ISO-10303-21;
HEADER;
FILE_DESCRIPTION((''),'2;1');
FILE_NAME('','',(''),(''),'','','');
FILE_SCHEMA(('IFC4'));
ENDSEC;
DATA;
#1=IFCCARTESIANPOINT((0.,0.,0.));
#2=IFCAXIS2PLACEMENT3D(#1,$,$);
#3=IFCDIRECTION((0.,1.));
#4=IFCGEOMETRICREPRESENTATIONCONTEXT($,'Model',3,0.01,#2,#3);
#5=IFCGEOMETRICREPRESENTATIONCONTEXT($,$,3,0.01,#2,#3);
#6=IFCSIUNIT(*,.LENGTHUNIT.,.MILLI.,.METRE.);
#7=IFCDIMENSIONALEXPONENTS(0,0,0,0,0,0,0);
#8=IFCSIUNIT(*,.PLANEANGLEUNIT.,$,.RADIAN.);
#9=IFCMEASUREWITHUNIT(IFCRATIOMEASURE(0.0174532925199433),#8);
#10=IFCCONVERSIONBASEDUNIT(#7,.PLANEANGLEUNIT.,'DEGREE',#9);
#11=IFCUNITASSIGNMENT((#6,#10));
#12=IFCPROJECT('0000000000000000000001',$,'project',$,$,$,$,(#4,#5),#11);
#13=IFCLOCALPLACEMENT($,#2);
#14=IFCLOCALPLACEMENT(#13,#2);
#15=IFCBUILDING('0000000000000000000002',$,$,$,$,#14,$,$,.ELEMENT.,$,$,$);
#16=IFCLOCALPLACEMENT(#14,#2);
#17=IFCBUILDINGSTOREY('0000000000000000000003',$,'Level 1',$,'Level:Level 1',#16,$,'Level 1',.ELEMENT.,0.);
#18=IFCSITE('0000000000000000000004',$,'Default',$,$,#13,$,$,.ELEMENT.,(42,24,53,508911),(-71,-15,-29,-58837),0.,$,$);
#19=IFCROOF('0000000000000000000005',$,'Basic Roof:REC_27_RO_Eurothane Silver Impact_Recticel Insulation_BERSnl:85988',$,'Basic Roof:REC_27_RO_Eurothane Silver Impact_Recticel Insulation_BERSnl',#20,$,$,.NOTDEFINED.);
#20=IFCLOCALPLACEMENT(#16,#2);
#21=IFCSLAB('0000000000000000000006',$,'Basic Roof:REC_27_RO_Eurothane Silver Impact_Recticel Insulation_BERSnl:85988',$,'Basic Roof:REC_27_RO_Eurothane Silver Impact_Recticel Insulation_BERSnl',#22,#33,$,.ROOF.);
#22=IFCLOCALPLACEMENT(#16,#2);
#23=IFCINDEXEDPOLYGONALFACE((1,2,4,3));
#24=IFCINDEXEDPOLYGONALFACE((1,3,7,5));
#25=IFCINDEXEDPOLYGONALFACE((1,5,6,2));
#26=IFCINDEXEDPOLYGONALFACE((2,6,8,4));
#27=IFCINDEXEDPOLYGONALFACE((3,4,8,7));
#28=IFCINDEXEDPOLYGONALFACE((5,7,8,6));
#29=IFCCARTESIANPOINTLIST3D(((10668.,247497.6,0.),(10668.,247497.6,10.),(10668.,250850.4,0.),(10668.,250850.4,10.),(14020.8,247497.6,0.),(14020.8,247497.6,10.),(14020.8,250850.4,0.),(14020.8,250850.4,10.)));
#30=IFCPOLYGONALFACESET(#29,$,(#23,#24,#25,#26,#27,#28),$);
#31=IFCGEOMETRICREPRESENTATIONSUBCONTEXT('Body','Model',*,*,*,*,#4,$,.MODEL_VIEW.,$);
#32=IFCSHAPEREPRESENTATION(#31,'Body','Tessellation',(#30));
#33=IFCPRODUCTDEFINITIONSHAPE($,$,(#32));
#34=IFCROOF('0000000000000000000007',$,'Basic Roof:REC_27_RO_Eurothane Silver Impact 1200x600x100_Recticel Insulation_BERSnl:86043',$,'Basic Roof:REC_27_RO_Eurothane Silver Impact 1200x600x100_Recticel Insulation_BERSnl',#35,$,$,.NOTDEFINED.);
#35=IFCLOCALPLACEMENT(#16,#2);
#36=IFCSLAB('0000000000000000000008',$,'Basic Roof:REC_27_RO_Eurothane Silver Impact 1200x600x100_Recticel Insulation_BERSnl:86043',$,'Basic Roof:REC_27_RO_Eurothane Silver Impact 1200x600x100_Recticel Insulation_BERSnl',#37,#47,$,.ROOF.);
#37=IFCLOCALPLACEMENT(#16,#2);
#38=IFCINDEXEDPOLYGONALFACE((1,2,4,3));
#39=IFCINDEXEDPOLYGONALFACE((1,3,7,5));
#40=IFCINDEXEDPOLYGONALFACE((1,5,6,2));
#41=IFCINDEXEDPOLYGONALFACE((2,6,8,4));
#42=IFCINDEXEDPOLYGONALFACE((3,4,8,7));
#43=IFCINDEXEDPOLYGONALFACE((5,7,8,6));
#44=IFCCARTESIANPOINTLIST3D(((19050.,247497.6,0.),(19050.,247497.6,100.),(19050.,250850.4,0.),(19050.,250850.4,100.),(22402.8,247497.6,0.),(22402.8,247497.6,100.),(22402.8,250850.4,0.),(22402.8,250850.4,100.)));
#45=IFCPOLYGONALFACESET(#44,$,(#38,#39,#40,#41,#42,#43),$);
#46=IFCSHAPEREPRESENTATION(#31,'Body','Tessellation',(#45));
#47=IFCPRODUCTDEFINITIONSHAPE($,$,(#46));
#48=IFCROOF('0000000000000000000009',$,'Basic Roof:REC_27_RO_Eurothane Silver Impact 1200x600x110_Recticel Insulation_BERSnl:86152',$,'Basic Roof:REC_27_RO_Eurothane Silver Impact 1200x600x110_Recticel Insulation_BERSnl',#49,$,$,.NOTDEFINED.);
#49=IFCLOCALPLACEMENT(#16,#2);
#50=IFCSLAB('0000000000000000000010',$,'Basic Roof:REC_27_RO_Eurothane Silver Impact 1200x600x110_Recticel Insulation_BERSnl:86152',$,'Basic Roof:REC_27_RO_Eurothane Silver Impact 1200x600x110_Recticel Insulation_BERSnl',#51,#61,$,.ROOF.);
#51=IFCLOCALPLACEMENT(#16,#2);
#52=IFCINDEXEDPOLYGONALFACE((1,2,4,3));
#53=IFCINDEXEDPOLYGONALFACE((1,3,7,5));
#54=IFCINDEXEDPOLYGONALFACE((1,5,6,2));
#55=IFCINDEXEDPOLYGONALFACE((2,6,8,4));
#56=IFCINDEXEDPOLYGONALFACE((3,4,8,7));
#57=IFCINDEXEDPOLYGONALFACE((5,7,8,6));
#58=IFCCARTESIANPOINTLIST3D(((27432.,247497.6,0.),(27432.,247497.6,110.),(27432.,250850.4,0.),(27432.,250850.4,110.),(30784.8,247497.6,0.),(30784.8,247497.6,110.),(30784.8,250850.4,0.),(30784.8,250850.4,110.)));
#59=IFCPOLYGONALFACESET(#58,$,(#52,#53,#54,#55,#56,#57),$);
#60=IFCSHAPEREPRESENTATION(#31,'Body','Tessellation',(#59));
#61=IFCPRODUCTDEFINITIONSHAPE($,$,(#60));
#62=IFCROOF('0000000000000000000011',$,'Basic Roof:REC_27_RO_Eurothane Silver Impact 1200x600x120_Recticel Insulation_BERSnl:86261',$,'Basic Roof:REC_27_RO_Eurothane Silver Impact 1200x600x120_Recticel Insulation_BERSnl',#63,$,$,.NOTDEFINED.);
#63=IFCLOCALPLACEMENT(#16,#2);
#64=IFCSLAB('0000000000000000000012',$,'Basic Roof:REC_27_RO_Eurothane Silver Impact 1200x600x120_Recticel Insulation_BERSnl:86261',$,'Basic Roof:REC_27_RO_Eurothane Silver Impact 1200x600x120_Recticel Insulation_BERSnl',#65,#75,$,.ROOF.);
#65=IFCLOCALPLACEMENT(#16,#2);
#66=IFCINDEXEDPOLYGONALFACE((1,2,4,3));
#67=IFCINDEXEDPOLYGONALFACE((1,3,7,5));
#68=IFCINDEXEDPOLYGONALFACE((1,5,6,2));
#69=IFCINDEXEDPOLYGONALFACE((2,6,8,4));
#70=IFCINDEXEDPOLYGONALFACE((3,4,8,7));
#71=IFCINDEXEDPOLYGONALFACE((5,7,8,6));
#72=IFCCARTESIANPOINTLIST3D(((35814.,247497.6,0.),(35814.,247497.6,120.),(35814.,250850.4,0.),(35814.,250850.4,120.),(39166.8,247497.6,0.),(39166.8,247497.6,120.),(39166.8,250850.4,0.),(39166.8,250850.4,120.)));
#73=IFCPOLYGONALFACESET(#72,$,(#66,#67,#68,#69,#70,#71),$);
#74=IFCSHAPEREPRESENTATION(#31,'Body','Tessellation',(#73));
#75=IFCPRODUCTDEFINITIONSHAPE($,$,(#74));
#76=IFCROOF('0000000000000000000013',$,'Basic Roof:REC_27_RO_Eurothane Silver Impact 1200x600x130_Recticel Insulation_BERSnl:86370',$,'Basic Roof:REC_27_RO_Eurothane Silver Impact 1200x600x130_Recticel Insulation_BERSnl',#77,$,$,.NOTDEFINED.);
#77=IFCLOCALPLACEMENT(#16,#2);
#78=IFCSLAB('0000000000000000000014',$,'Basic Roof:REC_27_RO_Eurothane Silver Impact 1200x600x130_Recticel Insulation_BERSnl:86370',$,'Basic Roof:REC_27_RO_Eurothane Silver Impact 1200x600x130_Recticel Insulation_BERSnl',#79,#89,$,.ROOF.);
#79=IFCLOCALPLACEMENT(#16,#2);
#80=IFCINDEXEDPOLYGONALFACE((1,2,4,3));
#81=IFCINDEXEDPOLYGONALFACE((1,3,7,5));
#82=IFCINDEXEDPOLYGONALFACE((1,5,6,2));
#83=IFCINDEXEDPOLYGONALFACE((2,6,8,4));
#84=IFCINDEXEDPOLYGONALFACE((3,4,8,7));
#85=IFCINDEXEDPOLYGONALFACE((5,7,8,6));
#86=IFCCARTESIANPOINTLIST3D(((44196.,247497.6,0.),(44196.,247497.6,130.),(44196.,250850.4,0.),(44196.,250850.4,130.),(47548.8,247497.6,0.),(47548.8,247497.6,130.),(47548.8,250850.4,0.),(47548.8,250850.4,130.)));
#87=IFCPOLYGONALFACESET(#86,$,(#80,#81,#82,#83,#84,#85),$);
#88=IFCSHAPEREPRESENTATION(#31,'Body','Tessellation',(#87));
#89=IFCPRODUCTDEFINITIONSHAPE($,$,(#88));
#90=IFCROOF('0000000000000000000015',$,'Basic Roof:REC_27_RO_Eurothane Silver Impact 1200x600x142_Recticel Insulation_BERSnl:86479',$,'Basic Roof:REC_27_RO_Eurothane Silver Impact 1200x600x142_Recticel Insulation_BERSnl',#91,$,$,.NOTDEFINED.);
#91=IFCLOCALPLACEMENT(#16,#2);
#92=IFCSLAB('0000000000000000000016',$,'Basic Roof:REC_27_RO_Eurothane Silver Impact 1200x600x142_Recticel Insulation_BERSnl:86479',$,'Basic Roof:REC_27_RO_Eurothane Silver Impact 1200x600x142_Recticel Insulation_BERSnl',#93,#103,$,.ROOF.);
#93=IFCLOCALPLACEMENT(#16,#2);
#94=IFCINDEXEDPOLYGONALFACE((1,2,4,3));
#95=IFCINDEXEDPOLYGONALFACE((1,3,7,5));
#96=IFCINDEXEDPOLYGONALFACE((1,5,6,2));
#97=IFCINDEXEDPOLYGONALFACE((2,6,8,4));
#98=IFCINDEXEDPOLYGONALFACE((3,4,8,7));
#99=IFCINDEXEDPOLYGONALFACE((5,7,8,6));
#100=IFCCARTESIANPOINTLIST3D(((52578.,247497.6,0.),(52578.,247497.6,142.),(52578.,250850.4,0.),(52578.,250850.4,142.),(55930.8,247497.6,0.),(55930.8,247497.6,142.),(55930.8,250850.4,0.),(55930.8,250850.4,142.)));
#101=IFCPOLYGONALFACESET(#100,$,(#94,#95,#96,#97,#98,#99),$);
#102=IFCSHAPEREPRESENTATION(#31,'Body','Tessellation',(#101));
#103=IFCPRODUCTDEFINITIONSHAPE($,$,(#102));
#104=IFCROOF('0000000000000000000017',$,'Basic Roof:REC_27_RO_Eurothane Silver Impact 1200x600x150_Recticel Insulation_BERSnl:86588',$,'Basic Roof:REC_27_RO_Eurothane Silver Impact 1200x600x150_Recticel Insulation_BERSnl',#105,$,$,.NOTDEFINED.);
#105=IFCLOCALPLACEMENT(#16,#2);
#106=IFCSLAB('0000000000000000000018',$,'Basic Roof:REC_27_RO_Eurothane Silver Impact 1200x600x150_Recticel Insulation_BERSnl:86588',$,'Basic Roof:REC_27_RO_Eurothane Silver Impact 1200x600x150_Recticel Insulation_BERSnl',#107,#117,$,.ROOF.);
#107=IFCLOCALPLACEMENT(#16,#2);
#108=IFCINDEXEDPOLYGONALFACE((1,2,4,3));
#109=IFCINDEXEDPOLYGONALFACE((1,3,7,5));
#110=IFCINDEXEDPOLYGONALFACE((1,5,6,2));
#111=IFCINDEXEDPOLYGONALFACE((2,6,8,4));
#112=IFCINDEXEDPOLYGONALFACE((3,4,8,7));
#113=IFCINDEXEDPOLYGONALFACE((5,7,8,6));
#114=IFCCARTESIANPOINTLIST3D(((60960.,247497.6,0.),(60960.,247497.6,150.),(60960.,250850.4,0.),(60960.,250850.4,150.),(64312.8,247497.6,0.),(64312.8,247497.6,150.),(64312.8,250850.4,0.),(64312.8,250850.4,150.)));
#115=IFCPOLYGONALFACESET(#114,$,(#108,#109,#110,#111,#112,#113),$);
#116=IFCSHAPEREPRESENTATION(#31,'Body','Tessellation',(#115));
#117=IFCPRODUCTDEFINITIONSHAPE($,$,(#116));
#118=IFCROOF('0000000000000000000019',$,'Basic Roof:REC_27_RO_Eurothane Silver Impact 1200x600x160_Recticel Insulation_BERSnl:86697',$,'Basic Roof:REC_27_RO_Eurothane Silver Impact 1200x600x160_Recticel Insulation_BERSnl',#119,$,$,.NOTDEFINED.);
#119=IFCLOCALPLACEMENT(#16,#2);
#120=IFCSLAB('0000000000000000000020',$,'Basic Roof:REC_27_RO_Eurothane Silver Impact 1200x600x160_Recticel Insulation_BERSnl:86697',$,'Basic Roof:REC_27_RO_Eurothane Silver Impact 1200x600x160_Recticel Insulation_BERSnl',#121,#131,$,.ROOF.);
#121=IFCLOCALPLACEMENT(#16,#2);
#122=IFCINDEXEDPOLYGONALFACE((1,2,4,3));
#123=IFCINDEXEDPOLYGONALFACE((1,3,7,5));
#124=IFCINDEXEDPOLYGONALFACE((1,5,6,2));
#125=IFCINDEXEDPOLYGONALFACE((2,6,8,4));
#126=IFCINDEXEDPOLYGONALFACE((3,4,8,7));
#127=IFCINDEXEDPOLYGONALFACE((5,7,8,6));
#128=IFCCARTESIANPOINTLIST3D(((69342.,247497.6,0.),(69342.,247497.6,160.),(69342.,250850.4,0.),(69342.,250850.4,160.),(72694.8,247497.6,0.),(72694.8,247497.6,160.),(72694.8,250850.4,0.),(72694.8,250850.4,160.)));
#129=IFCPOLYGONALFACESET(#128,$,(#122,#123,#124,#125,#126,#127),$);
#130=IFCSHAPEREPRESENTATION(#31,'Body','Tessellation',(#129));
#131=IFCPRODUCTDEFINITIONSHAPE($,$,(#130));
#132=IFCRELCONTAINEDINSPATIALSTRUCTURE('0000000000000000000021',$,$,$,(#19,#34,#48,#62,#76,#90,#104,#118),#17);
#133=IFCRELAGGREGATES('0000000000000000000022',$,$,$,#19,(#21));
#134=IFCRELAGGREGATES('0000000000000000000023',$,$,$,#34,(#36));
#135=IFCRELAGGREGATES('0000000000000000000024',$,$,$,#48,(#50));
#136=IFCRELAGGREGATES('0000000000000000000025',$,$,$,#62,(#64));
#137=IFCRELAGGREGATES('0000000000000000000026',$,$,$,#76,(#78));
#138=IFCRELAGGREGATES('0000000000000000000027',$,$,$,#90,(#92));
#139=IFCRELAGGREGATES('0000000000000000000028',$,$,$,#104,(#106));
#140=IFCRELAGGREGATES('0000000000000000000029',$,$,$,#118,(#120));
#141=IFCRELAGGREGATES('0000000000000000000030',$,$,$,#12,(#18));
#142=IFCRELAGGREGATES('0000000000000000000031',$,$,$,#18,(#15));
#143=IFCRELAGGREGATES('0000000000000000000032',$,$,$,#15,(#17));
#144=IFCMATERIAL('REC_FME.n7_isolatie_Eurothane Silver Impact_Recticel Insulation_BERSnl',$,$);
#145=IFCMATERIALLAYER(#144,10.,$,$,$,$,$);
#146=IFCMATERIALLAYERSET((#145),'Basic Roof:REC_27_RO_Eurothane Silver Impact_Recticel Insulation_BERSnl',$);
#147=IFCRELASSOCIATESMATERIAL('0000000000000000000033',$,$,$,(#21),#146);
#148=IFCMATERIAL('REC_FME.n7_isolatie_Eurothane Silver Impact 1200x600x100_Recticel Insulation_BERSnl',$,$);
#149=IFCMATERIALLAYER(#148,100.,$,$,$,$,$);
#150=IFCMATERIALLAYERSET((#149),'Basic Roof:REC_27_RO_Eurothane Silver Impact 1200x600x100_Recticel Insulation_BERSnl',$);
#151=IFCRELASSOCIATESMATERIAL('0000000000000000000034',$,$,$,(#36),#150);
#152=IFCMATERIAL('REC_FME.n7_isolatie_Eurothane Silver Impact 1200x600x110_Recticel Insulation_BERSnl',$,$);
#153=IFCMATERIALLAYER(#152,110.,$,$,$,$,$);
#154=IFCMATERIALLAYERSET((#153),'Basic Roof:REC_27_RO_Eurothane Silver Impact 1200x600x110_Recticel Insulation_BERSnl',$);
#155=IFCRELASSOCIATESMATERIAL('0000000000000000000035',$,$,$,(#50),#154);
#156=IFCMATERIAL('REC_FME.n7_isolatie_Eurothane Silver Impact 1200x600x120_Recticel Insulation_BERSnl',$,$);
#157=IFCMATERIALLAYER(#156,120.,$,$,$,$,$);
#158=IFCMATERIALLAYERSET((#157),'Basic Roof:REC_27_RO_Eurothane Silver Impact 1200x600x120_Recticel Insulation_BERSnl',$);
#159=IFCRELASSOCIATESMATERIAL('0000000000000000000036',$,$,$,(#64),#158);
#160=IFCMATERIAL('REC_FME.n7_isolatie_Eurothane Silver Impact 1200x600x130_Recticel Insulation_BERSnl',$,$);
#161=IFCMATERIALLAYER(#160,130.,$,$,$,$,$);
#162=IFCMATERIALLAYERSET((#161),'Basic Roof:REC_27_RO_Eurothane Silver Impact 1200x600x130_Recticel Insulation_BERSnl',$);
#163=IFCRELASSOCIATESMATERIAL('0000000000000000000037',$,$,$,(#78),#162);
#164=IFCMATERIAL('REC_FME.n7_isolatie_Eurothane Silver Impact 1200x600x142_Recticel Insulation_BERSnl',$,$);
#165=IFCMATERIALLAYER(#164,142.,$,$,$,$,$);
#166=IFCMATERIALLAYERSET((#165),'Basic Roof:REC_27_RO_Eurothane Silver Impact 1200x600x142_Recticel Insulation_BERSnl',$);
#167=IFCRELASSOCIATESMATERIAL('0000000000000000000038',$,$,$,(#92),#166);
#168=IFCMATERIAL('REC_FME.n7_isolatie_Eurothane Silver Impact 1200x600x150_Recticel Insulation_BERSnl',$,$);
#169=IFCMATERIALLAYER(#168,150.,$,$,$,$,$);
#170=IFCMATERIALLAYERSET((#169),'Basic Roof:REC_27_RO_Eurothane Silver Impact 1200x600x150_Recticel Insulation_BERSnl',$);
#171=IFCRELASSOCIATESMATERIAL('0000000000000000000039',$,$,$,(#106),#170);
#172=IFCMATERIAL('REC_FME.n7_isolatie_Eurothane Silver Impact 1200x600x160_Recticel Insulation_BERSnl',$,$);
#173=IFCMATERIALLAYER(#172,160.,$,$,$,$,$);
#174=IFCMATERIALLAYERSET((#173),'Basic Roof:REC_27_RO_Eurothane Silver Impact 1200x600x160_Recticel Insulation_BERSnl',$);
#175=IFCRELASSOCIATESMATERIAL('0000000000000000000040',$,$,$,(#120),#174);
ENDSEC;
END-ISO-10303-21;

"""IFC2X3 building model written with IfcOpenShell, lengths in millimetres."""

from ifc_helpers import new_model, entity, si_unit, converted_unit, direction, frame, frame_2d, origin, place, context, subcontext, project, spatial, rectangle, extrude, material, layer, layer_set, element, aggregate, save


model = new_model("IFC2X3")

# Units and contexts
model_context = context("Model", 3, precision=0.01, world=origin(), true_north=direction((0.0, 1.0)))
context_of_model = context(None, 3, precision=0.01, world=origin(), true_north=direction((0.0, 1.0)))
body_context = subcontext(model_context, "Body", "Model", "MODEL_VIEW")
ifc_project = project(units=[si_unit("LENGTHUNIT", "METRE", prefix="MILLI"), converted_unit("PLANEANGLEUNIT", "DEGREE", entity("IfcRatioMeasure", 0.0174532925199433), si_unit("PLANEANGLEUNIT", "RADIAN"), dimensions=[0, 0, 0, 0, 0, 0, 0])], contexts=[model_context, context_of_model])

# Site, building, storey
site_placement = place(None, origin())
site = spatial("IfcSite", under=ifc_project, at=site_placement, Name="Default", CompositionType="ELEMENT", RefLatitude=(42, 24, 53, 508911), RefLongitude=(-71, -15, -29, -58837), RefElevation=0.0)
building_placement = place(site_placement, origin())
building = spatial("IfcBuilding", under=site, at=building_placement, CompositionType="ELEMENT")
storey_placement = place(building_placement, origin())
storey = spatial("IfcBuildingStorey", under=building, at=storey_placement, Name="Level 1", ObjectType="Level:Level 1", LongName="Level 1", CompositionType="ELEMENT", Elevation=0.0)

# Roofs, slabs
roof_1_placement = place(storey_placement, frame((10668.0, 247497.6, 0.0)))
roof_1 = element("IfcRoof", 1, at=roof_1_placement, inside=storey, Name="Basic Roof:REC_27_RO_Eurothane Silver Impact_Recticel Insulation_BERSnl:85988", ObjectType="Basic Roof:REC_27_RO_Eurothane Silver Impact_Recticel Insulation_BERSnl", ShapeType="NOTDEFINED")
ifc_material_1 = material(Name="REC_FME.n7_isolatie_Eurothane Silver Impact_Recticel Insulation_BERSnl")
ifc_layer_1 = layer(ifc_material_1, 10.0)
ifc_layer_set_1 = layer_set([ifc_layer_1], Name="Basic Roof:REC_27_RO_Eurothane Silver Impact_Recticel Insulation_BERSnl")
slab_1_placement = place(roof_1_placement, origin())
slab_1 = element("IfcSlab", 2, at=slab_1_placement, material=ifc_layer_set_1, Name="Basic Roof:REC_27_RO_Eurothane Silver Impact_Recticel Insulation_BERSnl:85988", ObjectType="Basic Roof:REC_27_RO_Eurothane Silver Impact_Recticel Insulation_BERSnl", PredefinedType="ROOF", context=body_context, shape_type="SweptSolid", body=[
    extrude(rectangle(XDim=3352.8, YDim=3352.8, at=frame_2d((0.0, 0.0), x_axis=(-1.0, 0.0))), frame((1676.4, 1676.4, 0.0)), (0.0, 0.0, 1.0), 10.0),
])
aggregate(roof_1, [slab_1])
roof_2_placement = place(storey_placement, frame((19050.0, 247497.6, 0.0)))
roof_2 = element("IfcRoof", 3, at=roof_2_placement, inside=storey, Name="Basic Roof:REC_27_RO_Eurothane Silver Impact 1200x600x100_Recticel Insulation_BERSnl:86043", ObjectType="Basic Roof:REC_27_RO_Eurothane Silver Impact 1200x600x100_Recticel Insulation_BERSnl", ShapeType="NOTDEFINED")
ifc_material_2 = material(Name="REC_FME.n7_isolatie_Eurothane Silver Impact 1200x600x100_Recticel Insulation_BERSnl")
ifc_layer_2 = layer(ifc_material_2, 100.0)
ifc_layer_set_2 = layer_set([ifc_layer_2], Name="Basic Roof:REC_27_RO_Eurothane Silver Impact 1200x600x100_Recticel Insulation_BERSnl")
slab_2_placement = place(roof_2_placement, origin())
slab_2 = element("IfcSlab", 4, at=slab_2_placement, material=ifc_layer_set_2, Name="Basic Roof:REC_27_RO_Eurothane Silver Impact 1200x600x100_Recticel Insulation_BERSnl:86043", ObjectType="Basic Roof:REC_27_RO_Eurothane Silver Impact 1200x600x100_Recticel Insulation_BERSnl", PredefinedType="ROOF", context=body_context, shape_type="SweptSolid", body=[
    extrude(rectangle(XDim=3352.8, YDim=3352.8, at=frame_2d((0.0, 0.0), x_axis=(-1.0, 0.0))), frame((1676.4, 1676.4, 0.0)), (0.0, 0.0, 1.0), 100.0),
])
aggregate(roof_2, [slab_2])
roof_3_placement = place(storey_placement, frame((27432.0, 247497.6, 0.0)))
roof_3 = element("IfcRoof", 5, at=roof_3_placement, inside=storey, Name="Basic Roof:REC_27_RO_Eurothane Silver Impact 1200x600x110_Recticel Insulation_BERSnl:86152", ObjectType="Basic Roof:REC_27_RO_Eurothane Silver Impact 1200x600x110_Recticel Insulation_BERSnl", ShapeType="NOTDEFINED")
ifc_material_3 = material(Name="REC_FME.n7_isolatie_Eurothane Silver Impact 1200x600x110_Recticel Insulation_BERSnl")
ifc_layer_3 = layer(ifc_material_3, 110.0)
ifc_layer_set_3 = layer_set([ifc_layer_3], Name="Basic Roof:REC_27_RO_Eurothane Silver Impact 1200x600x110_Recticel Insulation_BERSnl")
slab_3_placement = place(roof_3_placement, origin())
slab_3 = element("IfcSlab", 6, at=slab_3_placement, material=ifc_layer_set_3, Name="Basic Roof:REC_27_RO_Eurothane Silver Impact 1200x600x110_Recticel Insulation_BERSnl:86152", ObjectType="Basic Roof:REC_27_RO_Eurothane Silver Impact 1200x600x110_Recticel Insulation_BERSnl", PredefinedType="ROOF", context=body_context, shape_type="SweptSolid", body=[
    extrude(rectangle(XDim=3352.8, YDim=3352.8, at=frame_2d((0.0, 0.0), x_axis=(-1.0, 0.0))), frame((1676.4, 1676.4, 0.0)), (0.0, 0.0, 1.0), 110.0),
])
aggregate(roof_3, [slab_3])
roof_4_placement = place(storey_placement, frame((35814.0, 247497.6, 0.0)))
roof_4 = element("IfcRoof", 7, at=roof_4_placement, inside=storey, Name="Basic Roof:REC_27_RO_Eurothane Silver Impact 1200x600x120_Recticel Insulation_BERSnl:86261", ObjectType="Basic Roof:REC_27_RO_Eurothane Silver Impact 1200x600x120_Recticel Insulation_BERSnl", ShapeType="NOTDEFINED")
ifc_material_4 = material(Name="REC_FME.n7_isolatie_Eurothane Silver Impact 1200x600x120_Recticel Insulation_BERSnl")
ifc_layer_4 = layer(ifc_material_4, 120.0)
ifc_layer_set_4 = layer_set([ifc_layer_4], Name="Basic Roof:REC_27_RO_Eurothane Silver Impact 1200x600x120_Recticel Insulation_BERSnl")
slab_4_placement = place(roof_4_placement, origin())
slab_4 = element("IfcSlab", 8, at=slab_4_placement, material=ifc_layer_set_4, Name="Basic Roof:REC_27_RO_Eurothane Silver Impact 1200x600x120_Recticel Insulation_BERSnl:86261", ObjectType="Basic Roof:REC_27_RO_Eurothane Silver Impact 1200x600x120_Recticel Insulation_BERSnl", PredefinedType="ROOF", context=body_context, shape_type="SweptSolid", body=[
    extrude(rectangle(XDim=3352.8, YDim=3352.8, at=frame_2d((0.0, 0.0), x_axis=(-1.0, 0.0))), frame((1676.4, 1676.4, 0.0)), (0.0, 0.0, 1.0), 120.0),
])
aggregate(roof_4, [slab_4])
roof_5_placement = place(storey_placement, frame((44196.0, 247497.6, 0.0)))
roof_5 = element("IfcRoof", 9, at=roof_5_placement, inside=storey, Name="Basic Roof:REC_27_RO_Eurothane Silver Impact 1200x600x130_Recticel Insulation_BERSnl:86370", ObjectType="Basic Roof:REC_27_RO_Eurothane Silver Impact 1200x600x130_Recticel Insulation_BERSnl", ShapeType="NOTDEFINED")
ifc_material_5 = material(Name="REC_FME.n7_isolatie_Eurothane Silver Impact 1200x600x130_Recticel Insulation_BERSnl")
ifc_layer_5 = layer(ifc_material_5, 130.0)
ifc_layer_set_5 = layer_set([ifc_layer_5], Name="Basic Roof:REC_27_RO_Eurothane Silver Impact 1200x600x130_Recticel Insulation_BERSnl")
slab_5_placement = place(roof_5_placement, origin())
slab_5 = element("IfcSlab", 10, at=slab_5_placement, material=ifc_layer_set_5, Name="Basic Roof:REC_27_RO_Eurothane Silver Impact 1200x600x130_Recticel Insulation_BERSnl:86370", ObjectType="Basic Roof:REC_27_RO_Eurothane Silver Impact 1200x600x130_Recticel Insulation_BERSnl", PredefinedType="ROOF", context=body_context, shape_type="SweptSolid", body=[
    extrude(rectangle(XDim=3352.8, YDim=3352.8, at=frame_2d((0.0, 0.0), x_axis=(-1.0, 0.0))), frame((1676.4, 1676.4, 0.0)), (0.0, 0.0, 1.0), 130.0),
])
aggregate(roof_5, [slab_5])
roof_6_placement = place(storey_placement, frame((52578.0, 247497.6, 0.0)))
roof_6 = element("IfcRoof", 11, at=roof_6_placement, inside=storey, Name="Basic Roof:REC_27_RO_Eurothane Silver Impact 1200x600x142_Recticel Insulation_BERSnl:86479", ObjectType="Basic Roof:REC_27_RO_Eurothane Silver Impact 1200x600x142_Recticel Insulation_BERSnl", ShapeType="NOTDEFINED")
ifc_material_6 = material(Name="REC_FME.n7_isolatie_Eurothane Silver Impact 1200x600x142_Recticel Insulation_BERSnl")
ifc_layer_6 = layer(ifc_material_6, 142.0)
ifc_layer_set_6 = layer_set([ifc_layer_6], Name="Basic Roof:REC_27_RO_Eurothane Silver Impact 1200x600x142_Recticel Insulation_BERSnl")
slab_6_placement = place(roof_6_placement, origin())
slab_6 = element("IfcSlab", 12, at=slab_6_placement, material=ifc_layer_set_6, Name="Basic Roof:REC_27_RO_Eurothane Silver Impact 1200x600x142_Recticel Insulation_BERSnl:86479", ObjectType="Basic Roof:REC_27_RO_Eurothane Silver Impact 1200x600x142_Recticel Insulation_BERSnl", PredefinedType="ROOF", context=body_context, shape_type="SweptSolid", body=[
    extrude(rectangle(XDim=3352.8, YDim=3352.8, at=frame_2d((0.0, 0.0), x_axis=(-1.0, 0.0))), frame((1676.4, 1676.4, 0.0)), (0.0, 0.0, 1.0), 142.0),
])
aggregate(roof_6, [slab_6])
roof_7_placement = place(storey_placement, frame((60960.0, 247497.6, 0.0)))
roof_7 = element("IfcRoof", 13, at=roof_7_placement, inside=storey, Name="Basic Roof:REC_27_RO_Eurothane Silver Impact 1200x600x150_Recticel Insulation_BERSnl:86588", ObjectType="Basic Roof:REC_27_RO_Eurothane Silver Impact 1200x600x150_Recticel Insulation_BERSnl", ShapeType="NOTDEFINED")
ifc_material_7 = material(Name="REC_FME.n7_isolatie_Eurothane Silver Impact 1200x600x150_Recticel Insulation_BERSnl")
ifc_layer_7 = layer(ifc_material_7, 150.0)
ifc_layer_set_7 = layer_set([ifc_layer_7], Name="Basic Roof:REC_27_RO_Eurothane Silver Impact 1200x600x150_Recticel Insulation_BERSnl")
slab_7_placement = place(roof_7_placement, origin())
slab_7 = element("IfcSlab", 14, at=slab_7_placement, material=ifc_layer_set_7, Name="Basic Roof:REC_27_RO_Eurothane Silver Impact 1200x600x150_Recticel Insulation_BERSnl:86588", ObjectType="Basic Roof:REC_27_RO_Eurothane Silver Impact 1200x600x150_Recticel Insulation_BERSnl", PredefinedType="ROOF", context=body_context, shape_type="SweptSolid", body=[
    extrude(rectangle(XDim=3352.8, YDim=3352.8, at=frame_2d((0.0, 0.0), x_axis=(-1.0, 0.0))), frame((1676.4, 1676.4, 0.0)), (0.0, 0.0, 1.0), 150.0),
])
aggregate(roof_7, [slab_7])
roof_8_placement = place(storey_placement, frame((69342.0, 247497.6, 0.0)))
roof_8 = element("IfcRoof", 15, at=roof_8_placement, inside=storey, Name="Basic Roof:REC_27_RO_Eurothane Silver Impact 1200x600x160_Recticel Insulation_BERSnl:86697", ObjectType="Basic Roof:REC_27_RO_Eurothane Silver Impact 1200x600x160_Recticel Insulation_BERSnl", ShapeType="NOTDEFINED")
ifc_material_8 = material(Name="REC_FME.n7_isolatie_Eurothane Silver Impact 1200x600x160_Recticel Insulation_BERSnl")
ifc_layer_8 = layer(ifc_material_8, 160.0)
ifc_layer_set_8 = layer_set([ifc_layer_8], Name="Basic Roof:REC_27_RO_Eurothane Silver Impact 1200x600x160_Recticel Insulation_BERSnl")
slab_8_placement = place(roof_8_placement, origin())
slab_8 = element("IfcSlab", 16, at=slab_8_placement, material=ifc_layer_set_8, Name="Basic Roof:REC_27_RO_Eurothane Silver Impact 1200x600x160_Recticel Insulation_BERSnl:86697", ObjectType="Basic Roof:REC_27_RO_Eurothane Silver Impact 1200x600x160_Recticel Insulation_BERSnl", PredefinedType="ROOF", context=body_context, shape_type="SweptSolid", body=[
    extrude(rectangle(XDim=3352.8, YDim=3352.8, at=frame_2d((0.0, 0.0), x_axis=(-1.0, 0.0))), frame((1676.4, 1676.4, 0.0)), (0.0, 0.0, 1.0), 160.0),
])
aggregate(roof_8, [slab_8])

save(model, "model.ifc")
